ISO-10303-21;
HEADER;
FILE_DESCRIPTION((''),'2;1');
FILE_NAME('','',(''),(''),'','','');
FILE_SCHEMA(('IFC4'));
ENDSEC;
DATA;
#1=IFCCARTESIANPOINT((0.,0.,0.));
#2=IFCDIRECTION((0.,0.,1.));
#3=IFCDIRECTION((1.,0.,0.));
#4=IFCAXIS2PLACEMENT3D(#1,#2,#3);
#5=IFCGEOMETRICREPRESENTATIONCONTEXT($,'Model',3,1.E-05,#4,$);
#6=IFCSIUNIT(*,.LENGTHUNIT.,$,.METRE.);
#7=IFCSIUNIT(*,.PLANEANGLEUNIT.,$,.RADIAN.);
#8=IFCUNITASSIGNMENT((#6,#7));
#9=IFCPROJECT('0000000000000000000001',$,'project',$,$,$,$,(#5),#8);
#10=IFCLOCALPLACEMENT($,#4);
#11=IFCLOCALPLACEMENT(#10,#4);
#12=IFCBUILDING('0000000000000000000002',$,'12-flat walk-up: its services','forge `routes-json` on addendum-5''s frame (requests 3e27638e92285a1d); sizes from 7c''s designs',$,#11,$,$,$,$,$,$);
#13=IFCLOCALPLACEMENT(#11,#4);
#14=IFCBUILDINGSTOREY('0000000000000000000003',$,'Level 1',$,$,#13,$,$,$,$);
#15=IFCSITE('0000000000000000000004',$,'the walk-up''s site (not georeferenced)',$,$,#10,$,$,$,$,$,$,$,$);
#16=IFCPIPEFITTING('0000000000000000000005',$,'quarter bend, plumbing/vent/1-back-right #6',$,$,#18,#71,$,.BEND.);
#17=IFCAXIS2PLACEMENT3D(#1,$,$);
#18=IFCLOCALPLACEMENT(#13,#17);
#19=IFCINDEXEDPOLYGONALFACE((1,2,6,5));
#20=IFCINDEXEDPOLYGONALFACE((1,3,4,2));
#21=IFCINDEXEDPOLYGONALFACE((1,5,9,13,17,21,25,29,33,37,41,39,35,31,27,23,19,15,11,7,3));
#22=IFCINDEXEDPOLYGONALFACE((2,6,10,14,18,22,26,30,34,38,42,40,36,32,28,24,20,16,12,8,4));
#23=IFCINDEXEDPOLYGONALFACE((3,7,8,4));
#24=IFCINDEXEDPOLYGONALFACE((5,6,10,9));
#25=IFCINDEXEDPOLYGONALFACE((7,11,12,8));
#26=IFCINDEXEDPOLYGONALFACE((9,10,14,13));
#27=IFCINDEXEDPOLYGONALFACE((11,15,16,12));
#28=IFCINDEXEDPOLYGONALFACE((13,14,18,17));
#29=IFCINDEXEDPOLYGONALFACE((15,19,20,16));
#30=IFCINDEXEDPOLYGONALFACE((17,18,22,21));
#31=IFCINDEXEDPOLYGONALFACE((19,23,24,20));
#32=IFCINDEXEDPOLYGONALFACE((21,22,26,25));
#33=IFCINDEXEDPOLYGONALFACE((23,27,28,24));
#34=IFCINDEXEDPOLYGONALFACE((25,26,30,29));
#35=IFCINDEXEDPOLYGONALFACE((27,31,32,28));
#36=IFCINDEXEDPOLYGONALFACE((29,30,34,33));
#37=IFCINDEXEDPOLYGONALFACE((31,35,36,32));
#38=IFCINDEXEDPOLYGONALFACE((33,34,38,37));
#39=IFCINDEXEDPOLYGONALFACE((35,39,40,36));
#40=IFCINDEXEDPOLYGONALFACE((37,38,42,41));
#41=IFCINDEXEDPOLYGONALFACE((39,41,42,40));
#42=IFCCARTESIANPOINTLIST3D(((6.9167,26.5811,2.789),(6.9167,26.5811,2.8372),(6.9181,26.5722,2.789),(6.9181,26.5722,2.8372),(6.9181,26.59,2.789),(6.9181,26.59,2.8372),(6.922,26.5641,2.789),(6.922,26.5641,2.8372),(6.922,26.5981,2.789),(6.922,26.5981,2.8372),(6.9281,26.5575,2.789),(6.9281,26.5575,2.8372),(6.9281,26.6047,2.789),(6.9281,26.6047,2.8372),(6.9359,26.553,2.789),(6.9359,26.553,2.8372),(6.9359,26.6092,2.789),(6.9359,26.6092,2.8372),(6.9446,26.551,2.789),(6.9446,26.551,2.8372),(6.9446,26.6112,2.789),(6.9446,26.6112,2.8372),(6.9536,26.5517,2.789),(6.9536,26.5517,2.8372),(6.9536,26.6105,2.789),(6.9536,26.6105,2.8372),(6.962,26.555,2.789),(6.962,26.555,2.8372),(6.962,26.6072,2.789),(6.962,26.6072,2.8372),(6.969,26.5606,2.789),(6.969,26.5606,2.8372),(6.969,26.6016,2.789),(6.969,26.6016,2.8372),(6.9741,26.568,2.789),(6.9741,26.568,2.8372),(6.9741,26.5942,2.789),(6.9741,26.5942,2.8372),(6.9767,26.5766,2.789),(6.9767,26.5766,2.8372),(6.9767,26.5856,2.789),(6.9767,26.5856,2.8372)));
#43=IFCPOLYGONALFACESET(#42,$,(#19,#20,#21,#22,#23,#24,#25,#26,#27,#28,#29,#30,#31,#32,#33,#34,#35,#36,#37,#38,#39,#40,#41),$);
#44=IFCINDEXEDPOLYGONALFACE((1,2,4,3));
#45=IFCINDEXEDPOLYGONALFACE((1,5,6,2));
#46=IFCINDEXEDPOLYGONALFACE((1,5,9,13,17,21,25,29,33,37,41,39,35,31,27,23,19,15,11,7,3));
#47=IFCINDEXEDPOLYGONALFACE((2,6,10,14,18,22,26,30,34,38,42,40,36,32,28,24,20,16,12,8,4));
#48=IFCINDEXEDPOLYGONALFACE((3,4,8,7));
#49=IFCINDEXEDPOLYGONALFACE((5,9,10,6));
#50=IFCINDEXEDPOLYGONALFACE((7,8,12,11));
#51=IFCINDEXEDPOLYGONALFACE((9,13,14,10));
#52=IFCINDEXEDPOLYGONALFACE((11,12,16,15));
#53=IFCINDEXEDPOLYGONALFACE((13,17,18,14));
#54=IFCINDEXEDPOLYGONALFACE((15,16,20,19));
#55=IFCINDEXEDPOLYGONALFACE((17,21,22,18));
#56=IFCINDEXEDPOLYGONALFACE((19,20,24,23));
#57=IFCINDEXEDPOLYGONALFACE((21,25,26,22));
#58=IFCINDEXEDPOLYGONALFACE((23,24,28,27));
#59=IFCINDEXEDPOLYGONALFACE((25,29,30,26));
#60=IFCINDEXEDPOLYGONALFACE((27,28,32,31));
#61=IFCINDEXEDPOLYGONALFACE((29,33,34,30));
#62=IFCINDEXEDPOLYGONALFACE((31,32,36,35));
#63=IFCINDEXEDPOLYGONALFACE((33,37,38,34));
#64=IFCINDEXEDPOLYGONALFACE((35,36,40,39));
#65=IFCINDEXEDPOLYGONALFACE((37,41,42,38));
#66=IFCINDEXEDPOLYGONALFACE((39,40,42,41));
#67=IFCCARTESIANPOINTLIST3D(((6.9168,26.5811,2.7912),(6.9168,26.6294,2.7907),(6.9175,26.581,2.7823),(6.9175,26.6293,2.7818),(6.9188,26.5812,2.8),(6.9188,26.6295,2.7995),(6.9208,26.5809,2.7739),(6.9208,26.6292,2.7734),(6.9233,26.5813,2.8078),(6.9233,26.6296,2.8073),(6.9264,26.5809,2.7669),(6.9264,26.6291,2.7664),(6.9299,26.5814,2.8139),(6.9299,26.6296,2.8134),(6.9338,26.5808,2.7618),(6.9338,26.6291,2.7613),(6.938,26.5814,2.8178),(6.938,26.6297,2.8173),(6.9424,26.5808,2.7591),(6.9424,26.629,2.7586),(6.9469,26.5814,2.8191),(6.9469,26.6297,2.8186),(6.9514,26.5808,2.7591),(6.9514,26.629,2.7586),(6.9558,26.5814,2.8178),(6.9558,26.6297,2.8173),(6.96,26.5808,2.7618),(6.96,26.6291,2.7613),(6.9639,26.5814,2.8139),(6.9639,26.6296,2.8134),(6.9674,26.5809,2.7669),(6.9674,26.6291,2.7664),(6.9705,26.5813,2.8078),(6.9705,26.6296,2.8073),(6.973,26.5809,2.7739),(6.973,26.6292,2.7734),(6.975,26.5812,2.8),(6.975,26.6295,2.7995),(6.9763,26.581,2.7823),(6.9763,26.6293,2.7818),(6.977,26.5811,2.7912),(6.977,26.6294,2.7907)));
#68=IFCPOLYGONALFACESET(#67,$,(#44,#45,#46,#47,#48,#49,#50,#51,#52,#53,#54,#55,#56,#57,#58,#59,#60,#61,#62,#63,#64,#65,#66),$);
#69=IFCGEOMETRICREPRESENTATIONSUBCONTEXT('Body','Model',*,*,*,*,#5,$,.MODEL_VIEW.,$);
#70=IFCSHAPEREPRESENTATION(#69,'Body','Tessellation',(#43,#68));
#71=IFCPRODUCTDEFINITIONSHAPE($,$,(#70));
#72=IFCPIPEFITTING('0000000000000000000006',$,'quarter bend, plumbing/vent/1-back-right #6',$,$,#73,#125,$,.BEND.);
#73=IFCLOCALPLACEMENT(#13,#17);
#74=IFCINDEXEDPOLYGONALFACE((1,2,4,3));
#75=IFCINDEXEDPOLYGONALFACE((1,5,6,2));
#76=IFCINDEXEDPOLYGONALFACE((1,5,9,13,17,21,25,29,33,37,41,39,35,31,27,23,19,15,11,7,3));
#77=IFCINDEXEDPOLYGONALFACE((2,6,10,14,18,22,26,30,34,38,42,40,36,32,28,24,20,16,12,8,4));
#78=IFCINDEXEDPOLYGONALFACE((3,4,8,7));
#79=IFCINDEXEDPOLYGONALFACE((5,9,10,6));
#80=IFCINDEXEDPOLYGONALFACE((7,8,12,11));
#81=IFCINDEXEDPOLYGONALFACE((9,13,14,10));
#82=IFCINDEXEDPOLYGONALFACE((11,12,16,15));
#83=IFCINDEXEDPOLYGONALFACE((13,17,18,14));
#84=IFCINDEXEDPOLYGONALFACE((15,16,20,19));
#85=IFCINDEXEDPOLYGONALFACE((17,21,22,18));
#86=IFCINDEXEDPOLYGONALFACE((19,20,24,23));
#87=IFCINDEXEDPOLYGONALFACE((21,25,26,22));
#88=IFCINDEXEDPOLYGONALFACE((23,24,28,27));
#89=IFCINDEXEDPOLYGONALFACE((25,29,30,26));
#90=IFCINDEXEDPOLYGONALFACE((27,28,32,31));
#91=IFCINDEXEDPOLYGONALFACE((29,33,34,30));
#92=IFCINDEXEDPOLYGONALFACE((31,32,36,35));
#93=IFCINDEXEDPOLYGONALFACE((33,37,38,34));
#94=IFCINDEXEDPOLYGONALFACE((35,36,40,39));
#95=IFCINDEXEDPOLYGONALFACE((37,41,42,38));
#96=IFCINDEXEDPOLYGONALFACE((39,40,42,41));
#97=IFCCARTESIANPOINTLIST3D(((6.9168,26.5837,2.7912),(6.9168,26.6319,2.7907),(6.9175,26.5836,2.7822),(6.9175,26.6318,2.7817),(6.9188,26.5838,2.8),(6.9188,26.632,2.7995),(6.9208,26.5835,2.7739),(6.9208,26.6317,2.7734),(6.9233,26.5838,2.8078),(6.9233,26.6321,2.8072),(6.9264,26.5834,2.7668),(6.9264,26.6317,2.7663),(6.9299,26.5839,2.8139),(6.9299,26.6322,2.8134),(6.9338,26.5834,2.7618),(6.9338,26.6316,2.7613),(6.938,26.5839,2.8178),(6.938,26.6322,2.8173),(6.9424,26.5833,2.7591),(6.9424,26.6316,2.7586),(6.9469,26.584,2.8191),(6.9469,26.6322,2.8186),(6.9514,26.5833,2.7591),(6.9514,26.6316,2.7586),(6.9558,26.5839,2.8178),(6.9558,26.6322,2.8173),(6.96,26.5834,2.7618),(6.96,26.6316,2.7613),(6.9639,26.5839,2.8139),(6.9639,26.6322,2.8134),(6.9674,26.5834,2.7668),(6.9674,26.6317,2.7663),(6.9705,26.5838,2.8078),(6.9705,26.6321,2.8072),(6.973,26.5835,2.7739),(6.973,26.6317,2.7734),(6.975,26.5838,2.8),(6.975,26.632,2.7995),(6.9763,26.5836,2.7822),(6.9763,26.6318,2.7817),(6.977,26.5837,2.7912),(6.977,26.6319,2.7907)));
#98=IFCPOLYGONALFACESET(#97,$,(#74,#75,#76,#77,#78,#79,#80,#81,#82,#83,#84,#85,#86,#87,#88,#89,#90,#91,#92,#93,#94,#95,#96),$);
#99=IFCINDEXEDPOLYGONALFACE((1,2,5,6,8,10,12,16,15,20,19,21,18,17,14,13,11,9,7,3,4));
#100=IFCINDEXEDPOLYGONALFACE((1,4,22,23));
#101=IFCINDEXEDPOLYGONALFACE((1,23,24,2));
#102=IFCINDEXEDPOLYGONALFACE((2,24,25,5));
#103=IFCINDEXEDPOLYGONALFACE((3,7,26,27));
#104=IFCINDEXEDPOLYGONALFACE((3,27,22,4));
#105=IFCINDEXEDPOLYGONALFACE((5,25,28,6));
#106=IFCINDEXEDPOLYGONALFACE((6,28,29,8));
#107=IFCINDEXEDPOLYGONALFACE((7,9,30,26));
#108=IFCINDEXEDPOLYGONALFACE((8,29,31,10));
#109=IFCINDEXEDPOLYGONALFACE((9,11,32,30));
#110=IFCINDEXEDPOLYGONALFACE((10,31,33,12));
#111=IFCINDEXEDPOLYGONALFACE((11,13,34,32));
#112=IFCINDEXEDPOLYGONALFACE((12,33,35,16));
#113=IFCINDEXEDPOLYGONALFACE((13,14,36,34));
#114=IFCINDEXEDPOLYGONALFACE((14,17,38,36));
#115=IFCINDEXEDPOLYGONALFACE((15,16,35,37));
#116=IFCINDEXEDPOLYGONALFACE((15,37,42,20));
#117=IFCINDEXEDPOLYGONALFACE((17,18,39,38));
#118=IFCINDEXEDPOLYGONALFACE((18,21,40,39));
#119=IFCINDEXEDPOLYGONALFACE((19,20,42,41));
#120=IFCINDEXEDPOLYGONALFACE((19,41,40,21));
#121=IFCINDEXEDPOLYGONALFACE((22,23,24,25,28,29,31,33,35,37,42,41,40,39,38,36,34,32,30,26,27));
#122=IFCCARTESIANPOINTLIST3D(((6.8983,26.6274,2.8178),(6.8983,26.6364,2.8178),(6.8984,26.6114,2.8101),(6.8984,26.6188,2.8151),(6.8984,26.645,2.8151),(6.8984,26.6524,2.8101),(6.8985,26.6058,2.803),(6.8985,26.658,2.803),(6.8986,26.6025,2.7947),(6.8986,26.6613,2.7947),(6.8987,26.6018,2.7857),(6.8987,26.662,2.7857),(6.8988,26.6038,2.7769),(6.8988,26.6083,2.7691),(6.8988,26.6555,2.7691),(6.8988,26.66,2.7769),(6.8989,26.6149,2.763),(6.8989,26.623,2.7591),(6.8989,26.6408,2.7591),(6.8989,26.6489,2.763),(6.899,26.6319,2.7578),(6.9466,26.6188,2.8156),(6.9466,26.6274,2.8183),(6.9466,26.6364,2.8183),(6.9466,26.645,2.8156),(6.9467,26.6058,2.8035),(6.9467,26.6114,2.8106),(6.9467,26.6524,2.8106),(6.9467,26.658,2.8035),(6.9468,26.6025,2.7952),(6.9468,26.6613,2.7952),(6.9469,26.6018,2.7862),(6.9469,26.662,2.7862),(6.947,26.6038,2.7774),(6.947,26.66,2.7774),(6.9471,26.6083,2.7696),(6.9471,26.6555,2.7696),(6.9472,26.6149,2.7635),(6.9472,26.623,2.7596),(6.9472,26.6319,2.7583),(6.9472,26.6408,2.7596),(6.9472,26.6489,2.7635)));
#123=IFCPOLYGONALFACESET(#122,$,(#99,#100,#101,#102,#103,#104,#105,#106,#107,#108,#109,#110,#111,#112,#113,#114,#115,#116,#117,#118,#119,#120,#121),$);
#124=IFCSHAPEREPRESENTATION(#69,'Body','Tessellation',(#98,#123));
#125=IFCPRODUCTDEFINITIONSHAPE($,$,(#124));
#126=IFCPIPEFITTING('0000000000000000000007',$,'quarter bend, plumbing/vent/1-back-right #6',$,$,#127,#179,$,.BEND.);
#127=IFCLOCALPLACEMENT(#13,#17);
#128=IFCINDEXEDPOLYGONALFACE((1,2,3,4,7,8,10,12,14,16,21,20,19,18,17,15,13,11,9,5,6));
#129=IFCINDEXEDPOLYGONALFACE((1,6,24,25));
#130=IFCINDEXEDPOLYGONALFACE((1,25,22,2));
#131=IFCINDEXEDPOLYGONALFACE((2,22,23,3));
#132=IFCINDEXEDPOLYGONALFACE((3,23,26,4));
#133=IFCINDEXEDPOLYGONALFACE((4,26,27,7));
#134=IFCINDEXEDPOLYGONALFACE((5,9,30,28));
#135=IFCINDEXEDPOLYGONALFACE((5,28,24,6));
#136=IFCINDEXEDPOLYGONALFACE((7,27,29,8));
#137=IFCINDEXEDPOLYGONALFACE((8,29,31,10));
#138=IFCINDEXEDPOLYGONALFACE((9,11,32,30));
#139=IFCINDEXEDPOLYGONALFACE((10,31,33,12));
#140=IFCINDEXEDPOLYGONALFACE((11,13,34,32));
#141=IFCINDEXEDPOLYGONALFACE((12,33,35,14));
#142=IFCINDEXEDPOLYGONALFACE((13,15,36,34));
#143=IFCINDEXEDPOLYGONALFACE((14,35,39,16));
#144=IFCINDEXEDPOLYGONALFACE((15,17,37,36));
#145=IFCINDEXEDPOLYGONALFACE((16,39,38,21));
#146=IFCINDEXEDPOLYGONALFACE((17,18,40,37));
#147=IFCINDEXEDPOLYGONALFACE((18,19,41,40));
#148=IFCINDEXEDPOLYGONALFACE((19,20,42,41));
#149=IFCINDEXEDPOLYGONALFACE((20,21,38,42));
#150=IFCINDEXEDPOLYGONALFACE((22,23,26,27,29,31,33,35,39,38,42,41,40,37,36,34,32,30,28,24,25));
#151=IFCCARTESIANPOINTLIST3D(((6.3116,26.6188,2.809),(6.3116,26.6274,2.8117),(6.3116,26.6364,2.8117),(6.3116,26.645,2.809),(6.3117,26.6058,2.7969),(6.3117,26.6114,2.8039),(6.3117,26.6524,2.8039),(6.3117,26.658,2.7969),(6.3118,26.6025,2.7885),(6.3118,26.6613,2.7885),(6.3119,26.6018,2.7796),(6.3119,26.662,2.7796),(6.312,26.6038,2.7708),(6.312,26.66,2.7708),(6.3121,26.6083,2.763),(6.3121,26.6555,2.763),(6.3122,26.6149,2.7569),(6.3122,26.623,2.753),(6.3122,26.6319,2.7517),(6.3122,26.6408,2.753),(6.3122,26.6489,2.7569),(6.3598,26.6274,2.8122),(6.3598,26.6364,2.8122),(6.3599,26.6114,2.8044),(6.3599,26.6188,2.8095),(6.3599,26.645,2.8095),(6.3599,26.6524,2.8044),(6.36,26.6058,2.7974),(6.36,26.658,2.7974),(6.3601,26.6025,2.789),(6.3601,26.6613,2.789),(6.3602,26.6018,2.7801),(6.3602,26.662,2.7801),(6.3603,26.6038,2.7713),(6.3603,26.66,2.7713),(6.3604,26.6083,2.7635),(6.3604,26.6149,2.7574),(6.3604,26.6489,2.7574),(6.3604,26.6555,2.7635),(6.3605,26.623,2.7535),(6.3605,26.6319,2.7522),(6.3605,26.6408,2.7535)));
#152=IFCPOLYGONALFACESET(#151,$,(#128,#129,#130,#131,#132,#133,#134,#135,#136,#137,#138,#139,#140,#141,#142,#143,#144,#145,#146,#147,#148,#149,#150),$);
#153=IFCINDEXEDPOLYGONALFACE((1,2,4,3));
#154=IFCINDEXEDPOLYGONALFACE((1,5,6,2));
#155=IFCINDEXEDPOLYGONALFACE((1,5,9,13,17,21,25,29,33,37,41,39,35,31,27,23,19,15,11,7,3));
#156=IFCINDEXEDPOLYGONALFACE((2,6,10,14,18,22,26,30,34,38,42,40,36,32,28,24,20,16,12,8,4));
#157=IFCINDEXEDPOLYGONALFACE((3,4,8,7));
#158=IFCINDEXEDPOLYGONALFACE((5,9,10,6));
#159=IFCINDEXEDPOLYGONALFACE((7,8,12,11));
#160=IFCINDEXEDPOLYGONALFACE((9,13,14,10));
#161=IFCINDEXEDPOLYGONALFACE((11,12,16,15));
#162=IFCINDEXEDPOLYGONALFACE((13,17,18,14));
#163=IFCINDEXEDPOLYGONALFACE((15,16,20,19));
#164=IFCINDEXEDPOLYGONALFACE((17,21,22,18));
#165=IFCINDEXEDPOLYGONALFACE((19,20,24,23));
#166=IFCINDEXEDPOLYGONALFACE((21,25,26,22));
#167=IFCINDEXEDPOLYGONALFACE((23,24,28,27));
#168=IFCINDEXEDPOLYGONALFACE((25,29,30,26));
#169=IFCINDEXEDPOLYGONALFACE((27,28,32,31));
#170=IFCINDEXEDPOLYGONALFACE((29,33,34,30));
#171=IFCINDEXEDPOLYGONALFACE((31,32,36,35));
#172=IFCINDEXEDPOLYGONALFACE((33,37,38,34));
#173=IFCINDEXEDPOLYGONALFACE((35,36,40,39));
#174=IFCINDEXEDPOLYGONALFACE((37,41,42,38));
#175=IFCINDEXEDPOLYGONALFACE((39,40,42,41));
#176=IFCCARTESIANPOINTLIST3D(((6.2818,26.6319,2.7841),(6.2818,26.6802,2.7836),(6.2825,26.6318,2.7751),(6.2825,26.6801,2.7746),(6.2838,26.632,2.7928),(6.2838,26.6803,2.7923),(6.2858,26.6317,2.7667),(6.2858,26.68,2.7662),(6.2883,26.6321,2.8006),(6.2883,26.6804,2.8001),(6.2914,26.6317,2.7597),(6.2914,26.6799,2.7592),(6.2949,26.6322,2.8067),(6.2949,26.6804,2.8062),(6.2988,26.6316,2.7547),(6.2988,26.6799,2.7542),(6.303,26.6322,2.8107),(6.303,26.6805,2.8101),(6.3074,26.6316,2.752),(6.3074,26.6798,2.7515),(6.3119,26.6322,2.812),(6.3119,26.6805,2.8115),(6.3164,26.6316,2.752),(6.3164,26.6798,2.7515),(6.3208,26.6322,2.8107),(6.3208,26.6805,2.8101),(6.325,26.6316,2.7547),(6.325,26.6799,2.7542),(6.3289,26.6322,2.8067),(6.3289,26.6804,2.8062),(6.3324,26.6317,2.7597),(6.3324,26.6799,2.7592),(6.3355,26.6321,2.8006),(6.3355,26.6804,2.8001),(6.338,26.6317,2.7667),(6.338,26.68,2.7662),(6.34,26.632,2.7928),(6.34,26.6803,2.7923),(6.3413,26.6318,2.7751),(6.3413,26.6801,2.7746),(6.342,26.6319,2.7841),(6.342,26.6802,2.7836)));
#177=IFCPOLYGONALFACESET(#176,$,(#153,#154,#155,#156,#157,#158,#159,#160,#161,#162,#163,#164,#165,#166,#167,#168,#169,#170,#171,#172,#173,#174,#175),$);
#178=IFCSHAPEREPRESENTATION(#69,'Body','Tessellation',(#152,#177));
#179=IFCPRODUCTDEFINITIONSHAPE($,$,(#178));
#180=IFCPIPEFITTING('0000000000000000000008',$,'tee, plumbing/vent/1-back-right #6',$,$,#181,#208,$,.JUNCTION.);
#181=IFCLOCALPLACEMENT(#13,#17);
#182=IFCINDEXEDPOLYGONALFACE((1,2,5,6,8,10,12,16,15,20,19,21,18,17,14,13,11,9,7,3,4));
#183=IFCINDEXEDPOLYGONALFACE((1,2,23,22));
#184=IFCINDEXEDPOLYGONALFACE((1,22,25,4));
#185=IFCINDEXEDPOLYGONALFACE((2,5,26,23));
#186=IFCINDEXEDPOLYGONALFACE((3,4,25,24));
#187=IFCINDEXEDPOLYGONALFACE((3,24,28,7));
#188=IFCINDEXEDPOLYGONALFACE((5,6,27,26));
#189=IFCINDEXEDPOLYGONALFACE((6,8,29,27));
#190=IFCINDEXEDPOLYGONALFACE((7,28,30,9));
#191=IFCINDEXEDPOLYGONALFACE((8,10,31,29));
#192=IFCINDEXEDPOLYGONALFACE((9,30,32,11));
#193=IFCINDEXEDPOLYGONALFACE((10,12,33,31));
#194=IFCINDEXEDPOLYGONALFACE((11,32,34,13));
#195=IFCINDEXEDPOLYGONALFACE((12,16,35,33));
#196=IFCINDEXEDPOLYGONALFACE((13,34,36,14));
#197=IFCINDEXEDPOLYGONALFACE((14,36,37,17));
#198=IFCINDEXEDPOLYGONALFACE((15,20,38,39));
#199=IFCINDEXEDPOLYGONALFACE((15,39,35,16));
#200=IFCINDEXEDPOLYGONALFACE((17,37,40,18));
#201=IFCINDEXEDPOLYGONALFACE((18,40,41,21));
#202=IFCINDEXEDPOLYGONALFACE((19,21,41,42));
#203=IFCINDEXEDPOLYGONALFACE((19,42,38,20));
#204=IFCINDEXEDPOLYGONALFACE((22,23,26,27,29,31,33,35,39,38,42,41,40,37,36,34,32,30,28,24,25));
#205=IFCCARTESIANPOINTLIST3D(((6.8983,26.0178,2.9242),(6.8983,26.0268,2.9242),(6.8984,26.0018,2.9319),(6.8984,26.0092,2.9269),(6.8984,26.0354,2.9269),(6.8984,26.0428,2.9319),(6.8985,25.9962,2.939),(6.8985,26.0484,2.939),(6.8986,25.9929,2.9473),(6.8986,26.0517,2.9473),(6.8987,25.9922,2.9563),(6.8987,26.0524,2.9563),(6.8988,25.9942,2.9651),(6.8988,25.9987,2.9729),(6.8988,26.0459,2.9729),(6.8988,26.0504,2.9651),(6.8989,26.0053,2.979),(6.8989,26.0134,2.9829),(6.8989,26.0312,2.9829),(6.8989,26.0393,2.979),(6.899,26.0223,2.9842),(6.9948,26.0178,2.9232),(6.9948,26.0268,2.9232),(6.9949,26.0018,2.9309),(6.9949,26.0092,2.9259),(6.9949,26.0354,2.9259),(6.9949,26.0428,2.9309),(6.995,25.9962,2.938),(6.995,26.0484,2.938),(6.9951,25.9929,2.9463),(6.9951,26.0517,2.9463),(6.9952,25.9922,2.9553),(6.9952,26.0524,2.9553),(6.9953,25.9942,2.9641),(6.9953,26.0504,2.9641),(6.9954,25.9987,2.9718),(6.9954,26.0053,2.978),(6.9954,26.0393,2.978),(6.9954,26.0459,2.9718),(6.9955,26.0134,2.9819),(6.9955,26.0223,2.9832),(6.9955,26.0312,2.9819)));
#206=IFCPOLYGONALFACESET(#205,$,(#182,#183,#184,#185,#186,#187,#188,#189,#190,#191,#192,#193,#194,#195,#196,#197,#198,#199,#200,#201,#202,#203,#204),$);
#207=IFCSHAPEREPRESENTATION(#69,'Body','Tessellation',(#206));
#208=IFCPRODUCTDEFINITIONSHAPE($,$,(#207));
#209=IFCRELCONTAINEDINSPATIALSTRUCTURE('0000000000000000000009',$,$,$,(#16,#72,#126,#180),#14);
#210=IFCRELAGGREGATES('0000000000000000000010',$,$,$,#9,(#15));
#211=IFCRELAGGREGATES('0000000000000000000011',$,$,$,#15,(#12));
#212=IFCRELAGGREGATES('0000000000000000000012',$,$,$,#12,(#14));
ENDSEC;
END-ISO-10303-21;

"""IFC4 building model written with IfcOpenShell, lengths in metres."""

from ifc_helpers import new_model, entity, si_unit, frame, origin_with_axes, place, context, subcontext, project, spatial, element, save


model = new_model("IFC4")

# Units and contexts
model_context = context("Model", 3, precision=1e-05, world=origin_with_axes())
body_context = subcontext(model_context, "Body", "Model", "MODEL_VIEW")
ifc_project = project(units=[si_unit("LENGTHUNIT", "METRE"), si_unit("PLANEANGLEUNIT", "RADIAN")], contexts=[model_context])

# Site, building, storey
site_placement = place(None, origin_with_axes())
site = spatial("IfcSite", under=ifc_project, at=site_placement, Name="the walk-up's site (not georeferenced)")
building_placement = place(site_placement, origin_with_axes())
building = spatial("IfcBuilding", under=site, at=building_placement, Name="12-flat walk-up: its services", Description="forge `routes-json` on addendum-5's frame (requests 3e27638e92285a1d); sizes from 7c's designs")
storey_placement = place(building_placement, origin_with_axes())
storey = spatial("IfcBuildingStorey", under=building, at=storey_placement, Name="Level 1")

# Pipe fittings
pipe_fitting_1_placement = place(storey_placement, frame((6.9469, 26.5811, 2.8372), z_axis=(0.0, 0.0, 1.0), x_axis=(1.0, 0.0, 0.0)))
element("IfcPipeFitting", 1, at=pipe_fitting_1_placement, inside=storey, Name="quarter bend, plumbing/vent/1-back-right #6", PredefinedType="BEND", context=body_context, shape_type="AdvancedSweptSolid", body=[
    entity("IfcSweptDiskSolid", entity("IfcPolyline", [entity("IfcCartesianPoint", [0.0, 0.0, 0.0]), entity("IfcCartesianPoint", [0.0, 0.0, -0.0483])]), 0.0302),
    entity("IfcSweptDiskSolid", entity("IfcPolyline", [entity("IfcCartesianPoint", [0.0, 0.0, -0.0483]), entity("IfcCartesianPoint", [0.0, 0.0483, -0.0488])]), 0.0302),
])
pipe_fitting_2_placement = place(storey_placement, frame((6.9469, 26.5836, 2.7889), z_axis=(0.0, 0.0, 1.0), x_axis=(1.0, 0.0, 0.0)))
element("IfcPipeFitting", 2, at=pipe_fitting_2_placement, inside=storey, Name="quarter bend, plumbing/vent/1-back-right #6", PredefinedType="BEND", context=body_context, shape_type="AdvancedSweptSolid", body=[
    entity("IfcSweptDiskSolid", entity("IfcPolyline", [entity("IfcCartesianPoint", [0.0, 0.0, 0.0]), entity("IfcCartesianPoint", [0.0, 0.0483, -0.0005])]), 0.0302),
    entity("IfcSweptDiskSolid", entity("IfcPolyline", [entity("IfcCartesianPoint", [0.0, 0.0483, -0.0005]), entity("IfcCartesianPoint", [-0.0483, 0.0483, -0.001])]), 0.0302),
])
pipe_fitting_3_placement = place(storey_placement, frame((6.3602, 26.6319, 2.7823), z_axis=(0.0, 0.0, 1.0), x_axis=(1.0, 0.0, 0.0)))
element("IfcPipeFitting", 3, at=pipe_fitting_3_placement, inside=storey, Name="quarter bend, plumbing/vent/1-back-right #6", PredefinedType="BEND", context=body_context, shape_type="AdvancedSweptSolid", body=[
    entity("IfcSweptDiskSolid", entity("IfcPolyline", [entity("IfcCartesianPoint", [0.0, 0.0, 0.0]), entity("IfcCartesianPoint", [-0.0483, 0.0, -0.0005])]), 0.0302),
    entity("IfcSweptDiskSolid", entity("IfcPolyline", [entity("IfcCartesianPoint", [-0.0483, 0.0, -0.0005]), entity("IfcCartesianPoint", [-0.0483, 0.0483, -0.001])]), 0.0302),
])
pipe_fitting_4_placement = place(storey_placement, frame((6.8986, 26.0223, 2.954), z_axis=(0.0, 0.0, 1.0), x_axis=(1.0, 0.0, 0.0)))
element("IfcPipeFitting", 4, at=pipe_fitting_4_placement, inside=storey, Name="tee, plumbing/vent/1-back-right #6", PredefinedType="JUNCTION", context=body_context, shape_type="AdvancedSweptSolid", body=[
    entity("IfcSweptDiskSolid", entity("IfcPolyline", [entity("IfcCartesianPoint", [0.0, 0.0, 0.0]), entity("IfcCartesianPoint", [0.0965, 0.0, -0.001])]), 0.0302),
])

save(model, "model.ifc")
